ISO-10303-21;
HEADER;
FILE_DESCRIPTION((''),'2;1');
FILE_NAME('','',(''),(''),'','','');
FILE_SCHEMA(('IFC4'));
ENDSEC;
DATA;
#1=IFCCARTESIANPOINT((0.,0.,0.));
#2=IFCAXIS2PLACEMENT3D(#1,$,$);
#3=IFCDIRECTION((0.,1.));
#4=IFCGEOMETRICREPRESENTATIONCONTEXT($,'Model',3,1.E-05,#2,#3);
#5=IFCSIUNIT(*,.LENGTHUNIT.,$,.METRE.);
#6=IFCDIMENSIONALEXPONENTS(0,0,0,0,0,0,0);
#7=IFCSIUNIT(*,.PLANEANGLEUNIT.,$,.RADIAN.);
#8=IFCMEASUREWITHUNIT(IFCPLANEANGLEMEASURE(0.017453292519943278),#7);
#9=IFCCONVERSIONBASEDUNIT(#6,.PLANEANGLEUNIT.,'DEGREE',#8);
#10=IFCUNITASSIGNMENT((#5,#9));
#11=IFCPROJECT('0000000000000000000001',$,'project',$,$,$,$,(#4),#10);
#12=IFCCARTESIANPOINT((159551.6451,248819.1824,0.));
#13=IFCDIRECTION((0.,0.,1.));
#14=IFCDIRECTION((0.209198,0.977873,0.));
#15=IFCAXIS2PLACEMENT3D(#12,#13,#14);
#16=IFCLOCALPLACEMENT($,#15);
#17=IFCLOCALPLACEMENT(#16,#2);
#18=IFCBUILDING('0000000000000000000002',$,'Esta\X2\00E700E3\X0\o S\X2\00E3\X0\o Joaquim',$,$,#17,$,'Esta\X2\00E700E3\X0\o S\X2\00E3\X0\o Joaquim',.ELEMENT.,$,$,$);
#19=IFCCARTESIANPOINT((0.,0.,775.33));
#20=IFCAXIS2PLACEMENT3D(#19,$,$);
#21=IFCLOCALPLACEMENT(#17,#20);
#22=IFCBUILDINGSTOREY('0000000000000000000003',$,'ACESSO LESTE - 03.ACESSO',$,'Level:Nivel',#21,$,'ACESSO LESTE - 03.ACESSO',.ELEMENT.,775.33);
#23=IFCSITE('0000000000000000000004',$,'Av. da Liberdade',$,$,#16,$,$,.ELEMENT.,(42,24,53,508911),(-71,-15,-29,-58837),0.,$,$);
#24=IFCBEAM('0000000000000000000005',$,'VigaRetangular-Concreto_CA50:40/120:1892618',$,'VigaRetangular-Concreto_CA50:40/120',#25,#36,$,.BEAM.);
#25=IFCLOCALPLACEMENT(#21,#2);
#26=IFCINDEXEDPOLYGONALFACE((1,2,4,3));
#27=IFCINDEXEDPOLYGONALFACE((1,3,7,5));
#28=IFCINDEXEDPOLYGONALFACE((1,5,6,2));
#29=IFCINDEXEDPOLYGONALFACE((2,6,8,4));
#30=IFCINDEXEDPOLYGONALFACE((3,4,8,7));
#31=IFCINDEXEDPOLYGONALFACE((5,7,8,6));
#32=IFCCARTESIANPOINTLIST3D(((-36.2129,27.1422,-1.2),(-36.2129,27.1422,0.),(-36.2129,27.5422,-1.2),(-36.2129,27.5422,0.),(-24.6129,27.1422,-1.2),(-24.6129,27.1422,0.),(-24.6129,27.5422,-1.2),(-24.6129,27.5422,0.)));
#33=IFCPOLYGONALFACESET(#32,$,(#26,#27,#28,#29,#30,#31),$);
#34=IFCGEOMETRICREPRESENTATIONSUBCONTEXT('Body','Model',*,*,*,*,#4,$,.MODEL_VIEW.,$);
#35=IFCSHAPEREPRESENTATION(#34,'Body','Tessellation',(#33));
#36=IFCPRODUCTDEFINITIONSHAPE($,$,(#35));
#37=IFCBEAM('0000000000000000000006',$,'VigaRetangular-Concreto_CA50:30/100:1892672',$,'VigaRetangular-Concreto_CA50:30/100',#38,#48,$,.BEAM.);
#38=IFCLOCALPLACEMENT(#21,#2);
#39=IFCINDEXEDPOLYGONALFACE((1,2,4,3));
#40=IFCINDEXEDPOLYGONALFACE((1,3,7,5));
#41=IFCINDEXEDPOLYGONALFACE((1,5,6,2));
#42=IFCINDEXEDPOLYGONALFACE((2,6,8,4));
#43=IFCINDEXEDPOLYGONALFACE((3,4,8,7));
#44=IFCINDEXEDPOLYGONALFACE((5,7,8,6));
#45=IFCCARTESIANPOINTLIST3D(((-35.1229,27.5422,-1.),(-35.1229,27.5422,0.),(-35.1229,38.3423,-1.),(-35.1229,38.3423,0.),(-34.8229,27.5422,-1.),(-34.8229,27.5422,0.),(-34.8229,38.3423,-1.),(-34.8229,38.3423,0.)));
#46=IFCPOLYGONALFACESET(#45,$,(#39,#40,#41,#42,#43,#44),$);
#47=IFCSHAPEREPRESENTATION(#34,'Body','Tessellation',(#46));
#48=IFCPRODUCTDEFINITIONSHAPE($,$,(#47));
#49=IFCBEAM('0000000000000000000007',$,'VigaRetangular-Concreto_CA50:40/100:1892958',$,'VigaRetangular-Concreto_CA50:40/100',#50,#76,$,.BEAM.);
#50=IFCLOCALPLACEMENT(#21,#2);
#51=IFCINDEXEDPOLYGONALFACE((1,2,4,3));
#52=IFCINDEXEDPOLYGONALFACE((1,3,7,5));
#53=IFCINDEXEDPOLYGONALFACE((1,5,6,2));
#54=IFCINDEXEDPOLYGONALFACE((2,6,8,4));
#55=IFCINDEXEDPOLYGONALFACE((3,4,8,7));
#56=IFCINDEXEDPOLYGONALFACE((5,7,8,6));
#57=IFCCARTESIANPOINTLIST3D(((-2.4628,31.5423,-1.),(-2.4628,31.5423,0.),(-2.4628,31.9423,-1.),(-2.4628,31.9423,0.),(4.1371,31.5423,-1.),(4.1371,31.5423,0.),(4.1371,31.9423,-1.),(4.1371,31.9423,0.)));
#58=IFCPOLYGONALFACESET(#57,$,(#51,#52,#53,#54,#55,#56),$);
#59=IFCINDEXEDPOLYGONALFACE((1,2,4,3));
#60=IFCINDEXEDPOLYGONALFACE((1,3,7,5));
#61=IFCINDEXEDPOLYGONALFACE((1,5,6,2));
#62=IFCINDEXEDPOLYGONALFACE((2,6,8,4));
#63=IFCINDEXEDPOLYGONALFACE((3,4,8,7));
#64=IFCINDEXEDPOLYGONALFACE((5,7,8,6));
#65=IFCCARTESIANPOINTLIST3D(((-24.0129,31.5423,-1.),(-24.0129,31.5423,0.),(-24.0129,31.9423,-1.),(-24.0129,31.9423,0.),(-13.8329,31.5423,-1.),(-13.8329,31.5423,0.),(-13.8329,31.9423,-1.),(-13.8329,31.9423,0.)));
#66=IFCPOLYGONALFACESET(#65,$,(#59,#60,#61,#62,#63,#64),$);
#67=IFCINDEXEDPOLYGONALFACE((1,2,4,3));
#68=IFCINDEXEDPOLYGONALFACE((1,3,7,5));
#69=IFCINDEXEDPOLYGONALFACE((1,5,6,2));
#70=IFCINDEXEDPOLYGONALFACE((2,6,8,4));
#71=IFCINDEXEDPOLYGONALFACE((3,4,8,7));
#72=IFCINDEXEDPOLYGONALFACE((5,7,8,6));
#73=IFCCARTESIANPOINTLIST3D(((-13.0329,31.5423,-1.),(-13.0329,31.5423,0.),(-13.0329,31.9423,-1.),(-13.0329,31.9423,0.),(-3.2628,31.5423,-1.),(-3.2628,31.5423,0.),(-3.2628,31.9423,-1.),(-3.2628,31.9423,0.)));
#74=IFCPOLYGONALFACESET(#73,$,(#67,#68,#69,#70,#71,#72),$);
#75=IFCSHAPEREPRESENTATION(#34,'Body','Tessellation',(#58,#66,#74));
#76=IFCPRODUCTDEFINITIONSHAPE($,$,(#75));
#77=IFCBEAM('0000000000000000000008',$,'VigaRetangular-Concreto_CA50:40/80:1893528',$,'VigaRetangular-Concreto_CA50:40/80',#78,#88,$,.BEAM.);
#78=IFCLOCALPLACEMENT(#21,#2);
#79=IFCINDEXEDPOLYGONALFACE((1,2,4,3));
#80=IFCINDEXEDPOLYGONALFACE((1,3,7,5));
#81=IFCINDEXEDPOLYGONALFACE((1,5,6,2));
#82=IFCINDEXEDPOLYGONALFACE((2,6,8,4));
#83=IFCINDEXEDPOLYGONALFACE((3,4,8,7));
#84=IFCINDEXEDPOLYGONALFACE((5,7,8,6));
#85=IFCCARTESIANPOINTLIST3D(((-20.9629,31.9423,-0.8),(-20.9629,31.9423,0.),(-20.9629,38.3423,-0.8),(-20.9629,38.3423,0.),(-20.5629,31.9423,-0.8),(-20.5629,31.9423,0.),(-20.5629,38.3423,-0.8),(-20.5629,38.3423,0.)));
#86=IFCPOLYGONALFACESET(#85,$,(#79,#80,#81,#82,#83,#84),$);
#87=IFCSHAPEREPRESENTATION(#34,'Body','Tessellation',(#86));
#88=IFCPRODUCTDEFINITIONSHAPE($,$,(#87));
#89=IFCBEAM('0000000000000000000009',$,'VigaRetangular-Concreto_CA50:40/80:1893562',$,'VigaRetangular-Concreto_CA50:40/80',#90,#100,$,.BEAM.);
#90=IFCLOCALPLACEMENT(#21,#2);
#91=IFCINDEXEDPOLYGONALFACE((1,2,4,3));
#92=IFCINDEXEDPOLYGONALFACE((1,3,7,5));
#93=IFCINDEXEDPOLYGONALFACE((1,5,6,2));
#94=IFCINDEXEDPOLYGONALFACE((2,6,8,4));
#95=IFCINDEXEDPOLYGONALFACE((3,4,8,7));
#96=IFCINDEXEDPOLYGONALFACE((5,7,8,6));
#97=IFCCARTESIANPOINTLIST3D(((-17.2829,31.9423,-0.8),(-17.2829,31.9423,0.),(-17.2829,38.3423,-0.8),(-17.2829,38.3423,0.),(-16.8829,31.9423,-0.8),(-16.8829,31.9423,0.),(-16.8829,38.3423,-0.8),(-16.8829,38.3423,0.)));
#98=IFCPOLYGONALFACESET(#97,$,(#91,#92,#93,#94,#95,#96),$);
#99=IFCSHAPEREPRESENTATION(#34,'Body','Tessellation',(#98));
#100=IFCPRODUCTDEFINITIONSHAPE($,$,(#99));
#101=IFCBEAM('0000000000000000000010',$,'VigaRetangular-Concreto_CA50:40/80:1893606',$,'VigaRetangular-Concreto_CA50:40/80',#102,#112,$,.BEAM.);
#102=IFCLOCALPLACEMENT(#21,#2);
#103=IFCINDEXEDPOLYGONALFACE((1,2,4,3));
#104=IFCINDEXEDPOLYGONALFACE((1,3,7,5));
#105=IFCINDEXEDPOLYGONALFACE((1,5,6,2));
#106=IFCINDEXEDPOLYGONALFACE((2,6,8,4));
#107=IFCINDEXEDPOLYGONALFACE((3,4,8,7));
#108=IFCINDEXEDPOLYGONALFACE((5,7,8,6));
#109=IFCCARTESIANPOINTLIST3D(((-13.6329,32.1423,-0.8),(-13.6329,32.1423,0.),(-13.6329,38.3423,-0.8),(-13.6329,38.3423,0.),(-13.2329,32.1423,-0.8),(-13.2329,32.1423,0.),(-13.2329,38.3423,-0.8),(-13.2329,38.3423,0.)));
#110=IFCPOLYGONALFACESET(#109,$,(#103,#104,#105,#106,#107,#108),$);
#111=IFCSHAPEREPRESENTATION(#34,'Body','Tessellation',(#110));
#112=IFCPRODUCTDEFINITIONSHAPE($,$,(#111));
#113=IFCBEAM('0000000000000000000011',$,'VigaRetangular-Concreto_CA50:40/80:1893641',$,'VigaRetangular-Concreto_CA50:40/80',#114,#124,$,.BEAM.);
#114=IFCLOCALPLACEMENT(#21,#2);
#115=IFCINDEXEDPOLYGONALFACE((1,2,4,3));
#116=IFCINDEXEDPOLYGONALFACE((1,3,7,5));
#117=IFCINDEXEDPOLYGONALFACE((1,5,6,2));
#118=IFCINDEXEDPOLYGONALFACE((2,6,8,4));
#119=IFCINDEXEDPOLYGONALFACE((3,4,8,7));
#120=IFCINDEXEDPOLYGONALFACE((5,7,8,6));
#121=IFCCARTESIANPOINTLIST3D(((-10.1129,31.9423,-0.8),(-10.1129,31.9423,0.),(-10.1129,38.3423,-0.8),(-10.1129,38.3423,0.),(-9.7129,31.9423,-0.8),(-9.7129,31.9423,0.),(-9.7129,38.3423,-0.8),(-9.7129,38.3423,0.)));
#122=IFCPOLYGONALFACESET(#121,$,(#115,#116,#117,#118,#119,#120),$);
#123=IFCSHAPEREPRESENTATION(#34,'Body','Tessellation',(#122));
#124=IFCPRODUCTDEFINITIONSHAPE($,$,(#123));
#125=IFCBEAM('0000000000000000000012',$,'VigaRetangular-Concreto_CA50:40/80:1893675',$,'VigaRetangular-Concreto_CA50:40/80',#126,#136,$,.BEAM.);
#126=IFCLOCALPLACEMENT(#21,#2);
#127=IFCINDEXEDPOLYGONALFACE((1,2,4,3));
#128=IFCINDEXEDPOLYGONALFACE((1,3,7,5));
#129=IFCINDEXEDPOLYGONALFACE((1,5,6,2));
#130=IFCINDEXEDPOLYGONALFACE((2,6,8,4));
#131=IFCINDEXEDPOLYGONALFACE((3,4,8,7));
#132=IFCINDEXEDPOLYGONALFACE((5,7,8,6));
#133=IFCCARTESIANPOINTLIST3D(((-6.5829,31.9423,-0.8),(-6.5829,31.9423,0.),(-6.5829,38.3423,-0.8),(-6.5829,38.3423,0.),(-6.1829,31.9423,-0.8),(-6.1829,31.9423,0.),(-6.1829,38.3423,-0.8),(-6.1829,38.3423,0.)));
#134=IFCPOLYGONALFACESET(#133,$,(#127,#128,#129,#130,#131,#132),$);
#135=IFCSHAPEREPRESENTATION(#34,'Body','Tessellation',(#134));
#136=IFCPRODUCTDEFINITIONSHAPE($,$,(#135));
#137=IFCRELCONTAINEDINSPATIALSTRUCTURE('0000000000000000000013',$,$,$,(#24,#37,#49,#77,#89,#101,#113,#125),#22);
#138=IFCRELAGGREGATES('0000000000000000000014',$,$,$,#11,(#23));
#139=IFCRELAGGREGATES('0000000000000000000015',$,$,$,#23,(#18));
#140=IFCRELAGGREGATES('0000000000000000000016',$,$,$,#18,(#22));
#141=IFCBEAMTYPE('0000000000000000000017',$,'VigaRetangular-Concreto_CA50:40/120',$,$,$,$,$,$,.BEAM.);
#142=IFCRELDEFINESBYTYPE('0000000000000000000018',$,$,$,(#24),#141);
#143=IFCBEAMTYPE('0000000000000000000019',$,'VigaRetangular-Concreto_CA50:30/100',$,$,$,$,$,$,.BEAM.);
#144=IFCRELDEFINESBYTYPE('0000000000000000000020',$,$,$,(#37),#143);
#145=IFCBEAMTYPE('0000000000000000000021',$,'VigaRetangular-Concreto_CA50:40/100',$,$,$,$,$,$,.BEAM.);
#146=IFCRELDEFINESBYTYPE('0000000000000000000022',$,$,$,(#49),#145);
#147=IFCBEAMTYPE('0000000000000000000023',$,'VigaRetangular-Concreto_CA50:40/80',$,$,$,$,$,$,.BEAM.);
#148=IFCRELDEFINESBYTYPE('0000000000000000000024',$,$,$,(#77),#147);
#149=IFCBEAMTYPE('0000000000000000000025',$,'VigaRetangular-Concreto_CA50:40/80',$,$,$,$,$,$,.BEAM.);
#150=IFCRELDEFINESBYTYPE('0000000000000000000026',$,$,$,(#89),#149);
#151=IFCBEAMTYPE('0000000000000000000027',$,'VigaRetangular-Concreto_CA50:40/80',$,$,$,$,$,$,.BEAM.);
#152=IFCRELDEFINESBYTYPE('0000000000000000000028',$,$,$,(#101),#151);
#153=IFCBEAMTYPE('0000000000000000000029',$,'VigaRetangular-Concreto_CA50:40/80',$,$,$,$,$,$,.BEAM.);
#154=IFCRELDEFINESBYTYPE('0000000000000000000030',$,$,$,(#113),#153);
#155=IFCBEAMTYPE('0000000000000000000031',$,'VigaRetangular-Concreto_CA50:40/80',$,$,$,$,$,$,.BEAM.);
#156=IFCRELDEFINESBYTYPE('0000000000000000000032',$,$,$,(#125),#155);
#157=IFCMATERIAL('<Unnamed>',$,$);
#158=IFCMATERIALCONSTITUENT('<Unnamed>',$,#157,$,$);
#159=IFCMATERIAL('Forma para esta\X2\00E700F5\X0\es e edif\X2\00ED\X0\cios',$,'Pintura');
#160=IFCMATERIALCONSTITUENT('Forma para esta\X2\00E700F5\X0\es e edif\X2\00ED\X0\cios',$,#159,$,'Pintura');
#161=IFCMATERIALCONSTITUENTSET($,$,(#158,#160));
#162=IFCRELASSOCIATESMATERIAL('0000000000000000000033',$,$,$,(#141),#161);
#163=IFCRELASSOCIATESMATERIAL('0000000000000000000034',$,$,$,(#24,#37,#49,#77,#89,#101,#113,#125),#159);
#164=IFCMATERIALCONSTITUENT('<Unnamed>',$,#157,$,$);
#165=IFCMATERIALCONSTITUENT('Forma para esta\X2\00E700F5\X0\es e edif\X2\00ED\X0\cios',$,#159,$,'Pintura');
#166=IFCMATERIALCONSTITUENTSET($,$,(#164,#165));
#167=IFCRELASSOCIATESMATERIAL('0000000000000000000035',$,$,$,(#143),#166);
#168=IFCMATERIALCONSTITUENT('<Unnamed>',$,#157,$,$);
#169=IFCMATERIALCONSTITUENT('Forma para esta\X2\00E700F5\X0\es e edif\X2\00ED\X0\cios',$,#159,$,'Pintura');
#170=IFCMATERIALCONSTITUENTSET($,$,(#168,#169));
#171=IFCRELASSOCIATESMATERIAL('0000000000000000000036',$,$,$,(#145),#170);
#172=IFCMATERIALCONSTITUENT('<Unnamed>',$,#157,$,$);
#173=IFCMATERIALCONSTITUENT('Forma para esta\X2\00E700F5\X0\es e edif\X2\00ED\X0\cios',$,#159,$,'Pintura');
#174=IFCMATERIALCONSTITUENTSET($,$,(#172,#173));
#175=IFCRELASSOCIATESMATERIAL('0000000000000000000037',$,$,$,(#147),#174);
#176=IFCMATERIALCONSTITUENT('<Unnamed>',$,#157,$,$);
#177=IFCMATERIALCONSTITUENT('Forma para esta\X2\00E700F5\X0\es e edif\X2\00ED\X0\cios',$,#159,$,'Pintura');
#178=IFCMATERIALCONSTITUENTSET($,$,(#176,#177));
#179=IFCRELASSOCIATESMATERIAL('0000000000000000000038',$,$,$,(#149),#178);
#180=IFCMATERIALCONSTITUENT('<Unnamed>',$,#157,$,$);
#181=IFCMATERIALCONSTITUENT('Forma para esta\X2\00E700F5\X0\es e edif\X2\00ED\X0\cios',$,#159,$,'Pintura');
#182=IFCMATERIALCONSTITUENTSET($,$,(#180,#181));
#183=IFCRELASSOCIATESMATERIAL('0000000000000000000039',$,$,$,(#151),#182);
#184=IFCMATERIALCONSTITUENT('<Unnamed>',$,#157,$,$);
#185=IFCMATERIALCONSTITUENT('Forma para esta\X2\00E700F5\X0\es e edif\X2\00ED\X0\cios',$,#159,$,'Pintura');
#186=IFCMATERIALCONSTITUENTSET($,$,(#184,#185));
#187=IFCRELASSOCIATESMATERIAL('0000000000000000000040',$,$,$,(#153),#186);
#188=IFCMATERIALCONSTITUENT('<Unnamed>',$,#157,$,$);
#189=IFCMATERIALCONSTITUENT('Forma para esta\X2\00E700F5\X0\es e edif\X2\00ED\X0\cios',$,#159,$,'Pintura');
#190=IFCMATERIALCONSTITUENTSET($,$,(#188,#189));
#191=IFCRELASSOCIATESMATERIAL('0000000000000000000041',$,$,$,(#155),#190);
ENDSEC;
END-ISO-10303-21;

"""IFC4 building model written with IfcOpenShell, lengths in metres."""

from ifc_helpers import new_model, entity, si_unit, converted_unit, direction, frame, origin, place, context, subcontext, project, spatial, indexed_curve, outline, extrude, source, transform, mapped, material, constituent, constituent_set, type_object, type_shapes, element, save


model = new_model("IFC4")

# Units and contexts
model_context = context("Model", 3, precision=1e-05, world=origin(), true_north=direction((0.0, 1.0)))
body_context = subcontext(model_context, "Body", "Model", "MODEL_VIEW")
ifc_project = project(units=[si_unit("LENGTHUNIT", "METRE"), converted_unit("PLANEANGLEUNIT", "DEGREE", entity("IfcPlaneAngleMeasure", 0.017453292519943278), si_unit("PLANEANGLEUNIT", "RADIAN"), dimensions=[0, 0, 0, 0, 0, 0, 0])], contexts=[model_context])

# Site, building, storey
site_placement = place(None, frame((159551.6451, 248819.1824, 0.0), z_axis=(0.0, 0.0, 1.0), x_axis=(0.209198, 0.977873, 0.0)))
site = spatial("IfcSite", under=ifc_project, at=site_placement, Name="Av. da Liberdade", CompositionType="ELEMENT", RefLatitude=(42, 24, 53, 508911), RefLongitude=(-71, -15, -29, -58837), RefElevation=0.0)
building_placement = place(site_placement, origin())
building = spatial("IfcBuilding", under=site, at=building_placement, Name="Estação São Joaquim", LongName="Estação São Joaquim", CompositionType="ELEMENT")
storey_placement = place(building_placement, frame((0.0, 0.0, 775.33)))
storey = spatial("IfcBuildingStorey", under=building, at=storey_placement, Name="ACESSO LESTE - 03.ACESSO", ObjectType="Level:Nivel", LongName="ACESSO LESTE - 03.ACESSO", CompositionType="ELEMENT", Elevation=775.33)

# Shared definitions
ifc_material_1 = material(Name="Forma para estações e edifícios", Category="Pintura")

# Beams
ifc_material_2 = material(Name="<Unnamed>")
ifc_constituent_1 = constituent(ifc_material_2, Name="<Unnamed>")
ifc_constituent_2 = constituent(ifc_material_1, Name="Forma para estações e edifícios", Category="Pintura")
ifc_constituent_set_1 = constituent_set(constituents=[ifc_constituent_1, ifc_constituent_2])
beam_type_1 = type_object("IfcBeamType", Name="VigaRetangular-Concreto_CA50:40/120", PredefinedType="BEAM", material=ifc_constituent_set_1)
shared_shape_1 = source(origin(), body_context, "Body", "SweptSolid", [
    extrude(outline(indexed_curve([(-0.6, -0.2), (0.6, -0.2), (0.6, 0.2), (-0.6, 0.2), (-0.6, -0.2)], self_intersect=False)), frame((-36.2129, 27.3422, 774.73), z_axis=(1.0, 0.0, 0.0), x_axis=(0.0, 0.0, -1.0)), (0.0, 0.0, 1.0), 11.6),
])
type_shapes(beam_type_1, [shared_shape_1])
beam_1_placement = place(storey_placement, frame((0.0, 0.0, -775.33)))
element("IfcBeam", 1, at=beam_1_placement, inside=storey, type_object=beam_type_1, material=ifc_material_1, Name="VigaRetangular-Concreto_CA50:40/120:1892618", ObjectType="VigaRetangular-Concreto_CA50:40/120", PredefinedType="BEAM", context=body_context, shape_type="MappedRepresentation", body=[
    mapped(shared_shape_1, transform((0.0, 0.0, 0.0), scale=1.0)),
])
ifc_constituent_3 = constituent(ifc_material_2, Name="<Unnamed>")
ifc_constituent_4 = constituent(ifc_material_1, Name="Forma para estações e edifícios", Category="Pintura")
ifc_constituent_set_2 = constituent_set(constituents=[ifc_constituent_3, ifc_constituent_4])
beam_type_2 = type_object("IfcBeamType", Name="VigaRetangular-Concreto_CA50:30/100", PredefinedType="BEAM", material=ifc_constituent_set_2)
shared_shape_2 = source(origin(), body_context, "Body", "SweptSolid", [
    extrude(outline(indexed_curve([(-0.15, -0.5), (0.15, -0.5), (0.15, 0.5), (-0.15, 0.5), (-0.15, -0.5)], self_intersect=False)), frame((-34.9729, 38.3423, 774.83), z_axis=(0.0, -1.0, 0.0), x_axis=(-1.0, 0.0, 0.0)), (0.0, 0.0, 1.0), 10.8001),
])
type_shapes(beam_type_2, [shared_shape_2])
beam_2_placement = place(storey_placement, frame((0.0, 0.0, -775.33)))
element("IfcBeam", 2, at=beam_2_placement, inside=storey, type_object=beam_type_2, material=ifc_material_1, Name="VigaRetangular-Concreto_CA50:30/100:1892672", ObjectType="VigaRetangular-Concreto_CA50:30/100", PredefinedType="BEAM", context=body_context, shape_type="MappedRepresentation", body=[
    mapped(shared_shape_2, transform((0.0, 0.0, 0.0), scale=1.0)),
])
ifc_constituent_5 = constituent(ifc_material_2, Name="<Unnamed>")
ifc_constituent_6 = constituent(ifc_material_1, Name="Forma para estações e edifícios", Category="Pintura")
ifc_constituent_set_3 = constituent_set(constituents=[ifc_constituent_5, ifc_constituent_6])
beam_type_3 = type_object("IfcBeamType", Name="VigaRetangular-Concreto_CA50:40/100", PredefinedType="BEAM", material=ifc_constituent_set_3)
shared_shape_3 = source(origin(), body_context, "Body", "SweptSolid", [
    extrude(outline(indexed_curve([(-0.5, -0.2), (0.5, -0.2), (0.5, 0.2), (-0.5, 0.2), (-0.5, -0.2)], self_intersect=False)), frame((-2.4628, 31.7423, 774.83), z_axis=(1.0, 0.0, 0.0), x_axis=(0.0, 0.0, -1.0)), (0.0, 0.0, 1.0), 6.5999),
    extrude(outline(indexed_curve([(-0.5, -0.2), (0.5, -0.2), (0.5, 0.2), (-0.5, 0.2), (-0.5, -0.2)], self_intersect=False)), frame((-24.0129, 31.7423, 774.83), z_axis=(1.0, 0.0, 0.0), x_axis=(0.0, 0.0, -1.0)), (0.0, 0.0, 1.0), 10.18),
    extrude(outline(indexed_curve([(-0.5, -0.2), (0.5, -0.2), (0.5, 0.2), (-0.5, 0.2), (-0.5, -0.2)], self_intersect=False)), frame((-13.0329, 31.7423, 774.83), z_axis=(1.0, 0.0, 0.0), x_axis=(0.0, 0.0, -1.0)), (0.0, 0.0, 1.0), 9.7701),
])
type_shapes(beam_type_3, [shared_shape_3])
beam_3_placement = place(storey_placement, frame((0.0, 0.0, -775.33)))
element("IfcBeam", 3, at=beam_3_placement, inside=storey, type_object=beam_type_3, material=ifc_material_1, Name="VigaRetangular-Concreto_CA50:40/100:1892958", ObjectType="VigaRetangular-Concreto_CA50:40/100", PredefinedType="BEAM", context=body_context, shape_type="MappedRepresentation", body=[
    mapped(shared_shape_3, transform((0.0, 0.0, 0.0), scale=1.0)),
])
ifc_constituent_7 = constituent(ifc_material_2, Name="<Unnamed>")
ifc_constituent_8 = constituent(ifc_material_1, Name="Forma para estações e edifícios", Category="Pintura")
ifc_constituent_set_4 = constituent_set(constituents=[ifc_constituent_7, ifc_constituent_8])
beam_type_4 = type_object("IfcBeamType", Name="VigaRetangular-Concreto_CA50:40/80", PredefinedType="BEAM", material=ifc_constituent_set_4)
shared_shape_4 = source(origin(), body_context, "Body", "SweptSolid", [
    extrude(outline(indexed_curve([(-0.2, -0.4), (0.2, -0.4), (0.2, 0.4), (-0.2, 0.4), (-0.2, -0.4)], self_intersect=False)), frame((-20.7629, 31.9423, 774.93), z_axis=(0.0, 1.0, 0.0), x_axis=(-1.0, 0.0, 0.0)), (0.0, 0.0, 1.0), 6.4),
])
type_shapes(beam_type_4, [shared_shape_4])
beam_4_placement = place(storey_placement, frame((0.0, 0.0, -775.33)))
element("IfcBeam", 4, at=beam_4_placement, inside=storey, type_object=beam_type_4, material=ifc_material_1, Name="VigaRetangular-Concreto_CA50:40/80:1893528", ObjectType="VigaRetangular-Concreto_CA50:40/80", PredefinedType="BEAM", context=body_context, shape_type="MappedRepresentation", body=[
    mapped(shared_shape_4, transform((0.0, 0.0, 0.0), scale=1.0)),
])
ifc_constituent_9 = constituent(ifc_material_2, Name="<Unnamed>")
ifc_constituent_10 = constituent(ifc_material_1, Name="Forma para estações e edifícios", Category="Pintura")
ifc_constituent_set_5 = constituent_set(constituents=[ifc_constituent_9, ifc_constituent_10])
beam_type_5 = type_object("IfcBeamType", Name="VigaRetangular-Concreto_CA50:40/80", PredefinedType="BEAM", material=ifc_constituent_set_5)
shared_shape_5 = source(origin(), body_context, "Body", "SweptSolid", [
    extrude(outline(indexed_curve([(-0.2, -0.4), (0.2, -0.4), (0.2, 0.4), (-0.2, 0.4), (-0.2, -0.4)], self_intersect=False)), frame((-17.0829, 38.3423, 774.93), z_axis=(0.0, -1.0, 0.0), x_axis=(-1.0, 0.0, 0.0)), (0.0, 0.0, 1.0), 6.4),
])
type_shapes(beam_type_5, [shared_shape_5])
beam_5_placement = place(storey_placement, frame((0.0, 0.0, -775.33)))
element("IfcBeam", 5, at=beam_5_placement, inside=storey, type_object=beam_type_5, material=ifc_material_1, Name="VigaRetangular-Concreto_CA50:40/80:1893562", ObjectType="VigaRetangular-Concreto_CA50:40/80", PredefinedType="BEAM", context=body_context, shape_type="MappedRepresentation", body=[
    mapped(shared_shape_5, transform((0.0, 0.0, 0.0), scale=1.0)),
])
ifc_constituent_11 = constituent(ifc_material_2, Name="<Unnamed>")
ifc_constituent_12 = constituent(ifc_material_1, Name="Forma para estações e edifícios", Category="Pintura")
ifc_constituent_set_6 = constituent_set(constituents=[ifc_constituent_11, ifc_constituent_12])
beam_type_6 = type_object("IfcBeamType", Name="VigaRetangular-Concreto_CA50:40/80", PredefinedType="BEAM", material=ifc_constituent_set_6)
shared_shape_6 = source(origin(), body_context, "Body", "SweptSolid", [
    extrude(outline(indexed_curve([(-0.2, -0.4), (0.2, -0.4), (0.2, 0.4), (-0.2, 0.4), (-0.2, -0.4)], self_intersect=False)), frame((-13.4329, 38.3423, 774.93), z_axis=(0.0, -1.0, 0.0), x_axis=(-1.0, 0.0, 0.0)), (0.0, 0.0, 1.0), 6.2),
])
type_shapes(beam_type_6, [shared_shape_6])
beam_6_placement = place(storey_placement, frame((0.0, 0.0, -775.33)))
element("IfcBeam", 6, at=beam_6_placement, inside=storey, type_object=beam_type_6, material=ifc_material_1, Name="VigaRetangular-Concreto_CA50:40/80:1893606", ObjectType="VigaRetangular-Concreto_CA50:40/80", PredefinedType="BEAM", context=body_context, shape_type="MappedRepresentation", body=[
    mapped(shared_shape_6, transform((0.0, 0.0, 0.0), scale=1.0)),
])
ifc_constituent_13 = constituent(ifc_material_2, Name="<Unnamed>")
ifc_constituent_14 = constituent(ifc_material_1, Name="Forma para estações e edifícios", Category="Pintura")
ifc_constituent_set_7 = constituent_set(constituents=[ifc_constituent_13, ifc_constituent_14])
beam_type_7 = type_object("IfcBeamType", Name="VigaRetangular-Concreto_CA50:40/80", PredefinedType="BEAM", material=ifc_constituent_set_7)
shared_shape_7 = source(origin(), body_context, "Body", "SweptSolid", [
    extrude(outline(indexed_curve([(-0.2, -0.4), (0.2, -0.4), (0.2, 0.4), (-0.2, 0.4), (-0.2, -0.4)], self_intersect=False)), frame((-9.9129, 38.3423, 774.93), z_axis=(0.0, -1.0, 0.0), x_axis=(-1.0, 0.0, 0.0)), (0.0, 0.0, 1.0), 6.4),
])
type_shapes(beam_type_7, [shared_shape_7])
beam_7_placement = place(storey_placement, frame((0.0, 0.0, -775.33)))
element("IfcBeam", 7, at=beam_7_placement, inside=storey, type_object=beam_type_7, material=ifc_material_1, Name="VigaRetangular-Concreto_CA50:40/80:1893641", ObjectType="VigaRetangular-Concreto_CA50:40/80", PredefinedType="BEAM", context=body_context, shape_type="MappedRepresentation", body=[
    mapped(shared_shape_7, transform((0.0, 0.0, 0.0), scale=1.0)),
])
ifc_constituent_15 = constituent(ifc_material_2, Name="<Unnamed>")
ifc_constituent_16 = constituent(ifc_material_1, Name="Forma para estações e edifícios", Category="Pintura")
ifc_constituent_set_8 = constituent_set(constituents=[ifc_constituent_15, ifc_constituent_16])
beam_type_8 = type_object("IfcBeamType", Name="VigaRetangular-Concreto_CA50:40/80", PredefinedType="BEAM", material=ifc_constituent_set_8)
shared_shape_8 = source(origin(), body_context, "Body", "SweptSolid", [
    extrude(outline(indexed_curve([(-0.2, -0.4), (0.2, -0.4), (0.2, 0.4), (-0.2, 0.4), (-0.2, -0.4)], self_intersect=False)), frame((-6.3829, 31.9423, 774.93), z_axis=(0.0, 1.0, 0.0), x_axis=(-1.0, 0.0, 0.0)), (0.0, 0.0, 1.0), 6.4),
])
type_shapes(beam_type_8, [shared_shape_8])
beam_8_placement = place(storey_placement, frame((0.0, 0.0, -775.33)))
element("IfcBeam", 8, at=beam_8_placement, inside=storey, type_object=beam_type_8, material=ifc_material_1, Name="VigaRetangular-Concreto_CA50:40/80:1893675", ObjectType="VigaRetangular-Concreto_CA50:40/80", PredefinedType="BEAM", context=body_context, shape_type="MappedRepresentation", body=[
    mapped(shared_shape_8, transform((0.0, 0.0, 0.0), scale=1.0)),
])

save(model, "model.ifc")
